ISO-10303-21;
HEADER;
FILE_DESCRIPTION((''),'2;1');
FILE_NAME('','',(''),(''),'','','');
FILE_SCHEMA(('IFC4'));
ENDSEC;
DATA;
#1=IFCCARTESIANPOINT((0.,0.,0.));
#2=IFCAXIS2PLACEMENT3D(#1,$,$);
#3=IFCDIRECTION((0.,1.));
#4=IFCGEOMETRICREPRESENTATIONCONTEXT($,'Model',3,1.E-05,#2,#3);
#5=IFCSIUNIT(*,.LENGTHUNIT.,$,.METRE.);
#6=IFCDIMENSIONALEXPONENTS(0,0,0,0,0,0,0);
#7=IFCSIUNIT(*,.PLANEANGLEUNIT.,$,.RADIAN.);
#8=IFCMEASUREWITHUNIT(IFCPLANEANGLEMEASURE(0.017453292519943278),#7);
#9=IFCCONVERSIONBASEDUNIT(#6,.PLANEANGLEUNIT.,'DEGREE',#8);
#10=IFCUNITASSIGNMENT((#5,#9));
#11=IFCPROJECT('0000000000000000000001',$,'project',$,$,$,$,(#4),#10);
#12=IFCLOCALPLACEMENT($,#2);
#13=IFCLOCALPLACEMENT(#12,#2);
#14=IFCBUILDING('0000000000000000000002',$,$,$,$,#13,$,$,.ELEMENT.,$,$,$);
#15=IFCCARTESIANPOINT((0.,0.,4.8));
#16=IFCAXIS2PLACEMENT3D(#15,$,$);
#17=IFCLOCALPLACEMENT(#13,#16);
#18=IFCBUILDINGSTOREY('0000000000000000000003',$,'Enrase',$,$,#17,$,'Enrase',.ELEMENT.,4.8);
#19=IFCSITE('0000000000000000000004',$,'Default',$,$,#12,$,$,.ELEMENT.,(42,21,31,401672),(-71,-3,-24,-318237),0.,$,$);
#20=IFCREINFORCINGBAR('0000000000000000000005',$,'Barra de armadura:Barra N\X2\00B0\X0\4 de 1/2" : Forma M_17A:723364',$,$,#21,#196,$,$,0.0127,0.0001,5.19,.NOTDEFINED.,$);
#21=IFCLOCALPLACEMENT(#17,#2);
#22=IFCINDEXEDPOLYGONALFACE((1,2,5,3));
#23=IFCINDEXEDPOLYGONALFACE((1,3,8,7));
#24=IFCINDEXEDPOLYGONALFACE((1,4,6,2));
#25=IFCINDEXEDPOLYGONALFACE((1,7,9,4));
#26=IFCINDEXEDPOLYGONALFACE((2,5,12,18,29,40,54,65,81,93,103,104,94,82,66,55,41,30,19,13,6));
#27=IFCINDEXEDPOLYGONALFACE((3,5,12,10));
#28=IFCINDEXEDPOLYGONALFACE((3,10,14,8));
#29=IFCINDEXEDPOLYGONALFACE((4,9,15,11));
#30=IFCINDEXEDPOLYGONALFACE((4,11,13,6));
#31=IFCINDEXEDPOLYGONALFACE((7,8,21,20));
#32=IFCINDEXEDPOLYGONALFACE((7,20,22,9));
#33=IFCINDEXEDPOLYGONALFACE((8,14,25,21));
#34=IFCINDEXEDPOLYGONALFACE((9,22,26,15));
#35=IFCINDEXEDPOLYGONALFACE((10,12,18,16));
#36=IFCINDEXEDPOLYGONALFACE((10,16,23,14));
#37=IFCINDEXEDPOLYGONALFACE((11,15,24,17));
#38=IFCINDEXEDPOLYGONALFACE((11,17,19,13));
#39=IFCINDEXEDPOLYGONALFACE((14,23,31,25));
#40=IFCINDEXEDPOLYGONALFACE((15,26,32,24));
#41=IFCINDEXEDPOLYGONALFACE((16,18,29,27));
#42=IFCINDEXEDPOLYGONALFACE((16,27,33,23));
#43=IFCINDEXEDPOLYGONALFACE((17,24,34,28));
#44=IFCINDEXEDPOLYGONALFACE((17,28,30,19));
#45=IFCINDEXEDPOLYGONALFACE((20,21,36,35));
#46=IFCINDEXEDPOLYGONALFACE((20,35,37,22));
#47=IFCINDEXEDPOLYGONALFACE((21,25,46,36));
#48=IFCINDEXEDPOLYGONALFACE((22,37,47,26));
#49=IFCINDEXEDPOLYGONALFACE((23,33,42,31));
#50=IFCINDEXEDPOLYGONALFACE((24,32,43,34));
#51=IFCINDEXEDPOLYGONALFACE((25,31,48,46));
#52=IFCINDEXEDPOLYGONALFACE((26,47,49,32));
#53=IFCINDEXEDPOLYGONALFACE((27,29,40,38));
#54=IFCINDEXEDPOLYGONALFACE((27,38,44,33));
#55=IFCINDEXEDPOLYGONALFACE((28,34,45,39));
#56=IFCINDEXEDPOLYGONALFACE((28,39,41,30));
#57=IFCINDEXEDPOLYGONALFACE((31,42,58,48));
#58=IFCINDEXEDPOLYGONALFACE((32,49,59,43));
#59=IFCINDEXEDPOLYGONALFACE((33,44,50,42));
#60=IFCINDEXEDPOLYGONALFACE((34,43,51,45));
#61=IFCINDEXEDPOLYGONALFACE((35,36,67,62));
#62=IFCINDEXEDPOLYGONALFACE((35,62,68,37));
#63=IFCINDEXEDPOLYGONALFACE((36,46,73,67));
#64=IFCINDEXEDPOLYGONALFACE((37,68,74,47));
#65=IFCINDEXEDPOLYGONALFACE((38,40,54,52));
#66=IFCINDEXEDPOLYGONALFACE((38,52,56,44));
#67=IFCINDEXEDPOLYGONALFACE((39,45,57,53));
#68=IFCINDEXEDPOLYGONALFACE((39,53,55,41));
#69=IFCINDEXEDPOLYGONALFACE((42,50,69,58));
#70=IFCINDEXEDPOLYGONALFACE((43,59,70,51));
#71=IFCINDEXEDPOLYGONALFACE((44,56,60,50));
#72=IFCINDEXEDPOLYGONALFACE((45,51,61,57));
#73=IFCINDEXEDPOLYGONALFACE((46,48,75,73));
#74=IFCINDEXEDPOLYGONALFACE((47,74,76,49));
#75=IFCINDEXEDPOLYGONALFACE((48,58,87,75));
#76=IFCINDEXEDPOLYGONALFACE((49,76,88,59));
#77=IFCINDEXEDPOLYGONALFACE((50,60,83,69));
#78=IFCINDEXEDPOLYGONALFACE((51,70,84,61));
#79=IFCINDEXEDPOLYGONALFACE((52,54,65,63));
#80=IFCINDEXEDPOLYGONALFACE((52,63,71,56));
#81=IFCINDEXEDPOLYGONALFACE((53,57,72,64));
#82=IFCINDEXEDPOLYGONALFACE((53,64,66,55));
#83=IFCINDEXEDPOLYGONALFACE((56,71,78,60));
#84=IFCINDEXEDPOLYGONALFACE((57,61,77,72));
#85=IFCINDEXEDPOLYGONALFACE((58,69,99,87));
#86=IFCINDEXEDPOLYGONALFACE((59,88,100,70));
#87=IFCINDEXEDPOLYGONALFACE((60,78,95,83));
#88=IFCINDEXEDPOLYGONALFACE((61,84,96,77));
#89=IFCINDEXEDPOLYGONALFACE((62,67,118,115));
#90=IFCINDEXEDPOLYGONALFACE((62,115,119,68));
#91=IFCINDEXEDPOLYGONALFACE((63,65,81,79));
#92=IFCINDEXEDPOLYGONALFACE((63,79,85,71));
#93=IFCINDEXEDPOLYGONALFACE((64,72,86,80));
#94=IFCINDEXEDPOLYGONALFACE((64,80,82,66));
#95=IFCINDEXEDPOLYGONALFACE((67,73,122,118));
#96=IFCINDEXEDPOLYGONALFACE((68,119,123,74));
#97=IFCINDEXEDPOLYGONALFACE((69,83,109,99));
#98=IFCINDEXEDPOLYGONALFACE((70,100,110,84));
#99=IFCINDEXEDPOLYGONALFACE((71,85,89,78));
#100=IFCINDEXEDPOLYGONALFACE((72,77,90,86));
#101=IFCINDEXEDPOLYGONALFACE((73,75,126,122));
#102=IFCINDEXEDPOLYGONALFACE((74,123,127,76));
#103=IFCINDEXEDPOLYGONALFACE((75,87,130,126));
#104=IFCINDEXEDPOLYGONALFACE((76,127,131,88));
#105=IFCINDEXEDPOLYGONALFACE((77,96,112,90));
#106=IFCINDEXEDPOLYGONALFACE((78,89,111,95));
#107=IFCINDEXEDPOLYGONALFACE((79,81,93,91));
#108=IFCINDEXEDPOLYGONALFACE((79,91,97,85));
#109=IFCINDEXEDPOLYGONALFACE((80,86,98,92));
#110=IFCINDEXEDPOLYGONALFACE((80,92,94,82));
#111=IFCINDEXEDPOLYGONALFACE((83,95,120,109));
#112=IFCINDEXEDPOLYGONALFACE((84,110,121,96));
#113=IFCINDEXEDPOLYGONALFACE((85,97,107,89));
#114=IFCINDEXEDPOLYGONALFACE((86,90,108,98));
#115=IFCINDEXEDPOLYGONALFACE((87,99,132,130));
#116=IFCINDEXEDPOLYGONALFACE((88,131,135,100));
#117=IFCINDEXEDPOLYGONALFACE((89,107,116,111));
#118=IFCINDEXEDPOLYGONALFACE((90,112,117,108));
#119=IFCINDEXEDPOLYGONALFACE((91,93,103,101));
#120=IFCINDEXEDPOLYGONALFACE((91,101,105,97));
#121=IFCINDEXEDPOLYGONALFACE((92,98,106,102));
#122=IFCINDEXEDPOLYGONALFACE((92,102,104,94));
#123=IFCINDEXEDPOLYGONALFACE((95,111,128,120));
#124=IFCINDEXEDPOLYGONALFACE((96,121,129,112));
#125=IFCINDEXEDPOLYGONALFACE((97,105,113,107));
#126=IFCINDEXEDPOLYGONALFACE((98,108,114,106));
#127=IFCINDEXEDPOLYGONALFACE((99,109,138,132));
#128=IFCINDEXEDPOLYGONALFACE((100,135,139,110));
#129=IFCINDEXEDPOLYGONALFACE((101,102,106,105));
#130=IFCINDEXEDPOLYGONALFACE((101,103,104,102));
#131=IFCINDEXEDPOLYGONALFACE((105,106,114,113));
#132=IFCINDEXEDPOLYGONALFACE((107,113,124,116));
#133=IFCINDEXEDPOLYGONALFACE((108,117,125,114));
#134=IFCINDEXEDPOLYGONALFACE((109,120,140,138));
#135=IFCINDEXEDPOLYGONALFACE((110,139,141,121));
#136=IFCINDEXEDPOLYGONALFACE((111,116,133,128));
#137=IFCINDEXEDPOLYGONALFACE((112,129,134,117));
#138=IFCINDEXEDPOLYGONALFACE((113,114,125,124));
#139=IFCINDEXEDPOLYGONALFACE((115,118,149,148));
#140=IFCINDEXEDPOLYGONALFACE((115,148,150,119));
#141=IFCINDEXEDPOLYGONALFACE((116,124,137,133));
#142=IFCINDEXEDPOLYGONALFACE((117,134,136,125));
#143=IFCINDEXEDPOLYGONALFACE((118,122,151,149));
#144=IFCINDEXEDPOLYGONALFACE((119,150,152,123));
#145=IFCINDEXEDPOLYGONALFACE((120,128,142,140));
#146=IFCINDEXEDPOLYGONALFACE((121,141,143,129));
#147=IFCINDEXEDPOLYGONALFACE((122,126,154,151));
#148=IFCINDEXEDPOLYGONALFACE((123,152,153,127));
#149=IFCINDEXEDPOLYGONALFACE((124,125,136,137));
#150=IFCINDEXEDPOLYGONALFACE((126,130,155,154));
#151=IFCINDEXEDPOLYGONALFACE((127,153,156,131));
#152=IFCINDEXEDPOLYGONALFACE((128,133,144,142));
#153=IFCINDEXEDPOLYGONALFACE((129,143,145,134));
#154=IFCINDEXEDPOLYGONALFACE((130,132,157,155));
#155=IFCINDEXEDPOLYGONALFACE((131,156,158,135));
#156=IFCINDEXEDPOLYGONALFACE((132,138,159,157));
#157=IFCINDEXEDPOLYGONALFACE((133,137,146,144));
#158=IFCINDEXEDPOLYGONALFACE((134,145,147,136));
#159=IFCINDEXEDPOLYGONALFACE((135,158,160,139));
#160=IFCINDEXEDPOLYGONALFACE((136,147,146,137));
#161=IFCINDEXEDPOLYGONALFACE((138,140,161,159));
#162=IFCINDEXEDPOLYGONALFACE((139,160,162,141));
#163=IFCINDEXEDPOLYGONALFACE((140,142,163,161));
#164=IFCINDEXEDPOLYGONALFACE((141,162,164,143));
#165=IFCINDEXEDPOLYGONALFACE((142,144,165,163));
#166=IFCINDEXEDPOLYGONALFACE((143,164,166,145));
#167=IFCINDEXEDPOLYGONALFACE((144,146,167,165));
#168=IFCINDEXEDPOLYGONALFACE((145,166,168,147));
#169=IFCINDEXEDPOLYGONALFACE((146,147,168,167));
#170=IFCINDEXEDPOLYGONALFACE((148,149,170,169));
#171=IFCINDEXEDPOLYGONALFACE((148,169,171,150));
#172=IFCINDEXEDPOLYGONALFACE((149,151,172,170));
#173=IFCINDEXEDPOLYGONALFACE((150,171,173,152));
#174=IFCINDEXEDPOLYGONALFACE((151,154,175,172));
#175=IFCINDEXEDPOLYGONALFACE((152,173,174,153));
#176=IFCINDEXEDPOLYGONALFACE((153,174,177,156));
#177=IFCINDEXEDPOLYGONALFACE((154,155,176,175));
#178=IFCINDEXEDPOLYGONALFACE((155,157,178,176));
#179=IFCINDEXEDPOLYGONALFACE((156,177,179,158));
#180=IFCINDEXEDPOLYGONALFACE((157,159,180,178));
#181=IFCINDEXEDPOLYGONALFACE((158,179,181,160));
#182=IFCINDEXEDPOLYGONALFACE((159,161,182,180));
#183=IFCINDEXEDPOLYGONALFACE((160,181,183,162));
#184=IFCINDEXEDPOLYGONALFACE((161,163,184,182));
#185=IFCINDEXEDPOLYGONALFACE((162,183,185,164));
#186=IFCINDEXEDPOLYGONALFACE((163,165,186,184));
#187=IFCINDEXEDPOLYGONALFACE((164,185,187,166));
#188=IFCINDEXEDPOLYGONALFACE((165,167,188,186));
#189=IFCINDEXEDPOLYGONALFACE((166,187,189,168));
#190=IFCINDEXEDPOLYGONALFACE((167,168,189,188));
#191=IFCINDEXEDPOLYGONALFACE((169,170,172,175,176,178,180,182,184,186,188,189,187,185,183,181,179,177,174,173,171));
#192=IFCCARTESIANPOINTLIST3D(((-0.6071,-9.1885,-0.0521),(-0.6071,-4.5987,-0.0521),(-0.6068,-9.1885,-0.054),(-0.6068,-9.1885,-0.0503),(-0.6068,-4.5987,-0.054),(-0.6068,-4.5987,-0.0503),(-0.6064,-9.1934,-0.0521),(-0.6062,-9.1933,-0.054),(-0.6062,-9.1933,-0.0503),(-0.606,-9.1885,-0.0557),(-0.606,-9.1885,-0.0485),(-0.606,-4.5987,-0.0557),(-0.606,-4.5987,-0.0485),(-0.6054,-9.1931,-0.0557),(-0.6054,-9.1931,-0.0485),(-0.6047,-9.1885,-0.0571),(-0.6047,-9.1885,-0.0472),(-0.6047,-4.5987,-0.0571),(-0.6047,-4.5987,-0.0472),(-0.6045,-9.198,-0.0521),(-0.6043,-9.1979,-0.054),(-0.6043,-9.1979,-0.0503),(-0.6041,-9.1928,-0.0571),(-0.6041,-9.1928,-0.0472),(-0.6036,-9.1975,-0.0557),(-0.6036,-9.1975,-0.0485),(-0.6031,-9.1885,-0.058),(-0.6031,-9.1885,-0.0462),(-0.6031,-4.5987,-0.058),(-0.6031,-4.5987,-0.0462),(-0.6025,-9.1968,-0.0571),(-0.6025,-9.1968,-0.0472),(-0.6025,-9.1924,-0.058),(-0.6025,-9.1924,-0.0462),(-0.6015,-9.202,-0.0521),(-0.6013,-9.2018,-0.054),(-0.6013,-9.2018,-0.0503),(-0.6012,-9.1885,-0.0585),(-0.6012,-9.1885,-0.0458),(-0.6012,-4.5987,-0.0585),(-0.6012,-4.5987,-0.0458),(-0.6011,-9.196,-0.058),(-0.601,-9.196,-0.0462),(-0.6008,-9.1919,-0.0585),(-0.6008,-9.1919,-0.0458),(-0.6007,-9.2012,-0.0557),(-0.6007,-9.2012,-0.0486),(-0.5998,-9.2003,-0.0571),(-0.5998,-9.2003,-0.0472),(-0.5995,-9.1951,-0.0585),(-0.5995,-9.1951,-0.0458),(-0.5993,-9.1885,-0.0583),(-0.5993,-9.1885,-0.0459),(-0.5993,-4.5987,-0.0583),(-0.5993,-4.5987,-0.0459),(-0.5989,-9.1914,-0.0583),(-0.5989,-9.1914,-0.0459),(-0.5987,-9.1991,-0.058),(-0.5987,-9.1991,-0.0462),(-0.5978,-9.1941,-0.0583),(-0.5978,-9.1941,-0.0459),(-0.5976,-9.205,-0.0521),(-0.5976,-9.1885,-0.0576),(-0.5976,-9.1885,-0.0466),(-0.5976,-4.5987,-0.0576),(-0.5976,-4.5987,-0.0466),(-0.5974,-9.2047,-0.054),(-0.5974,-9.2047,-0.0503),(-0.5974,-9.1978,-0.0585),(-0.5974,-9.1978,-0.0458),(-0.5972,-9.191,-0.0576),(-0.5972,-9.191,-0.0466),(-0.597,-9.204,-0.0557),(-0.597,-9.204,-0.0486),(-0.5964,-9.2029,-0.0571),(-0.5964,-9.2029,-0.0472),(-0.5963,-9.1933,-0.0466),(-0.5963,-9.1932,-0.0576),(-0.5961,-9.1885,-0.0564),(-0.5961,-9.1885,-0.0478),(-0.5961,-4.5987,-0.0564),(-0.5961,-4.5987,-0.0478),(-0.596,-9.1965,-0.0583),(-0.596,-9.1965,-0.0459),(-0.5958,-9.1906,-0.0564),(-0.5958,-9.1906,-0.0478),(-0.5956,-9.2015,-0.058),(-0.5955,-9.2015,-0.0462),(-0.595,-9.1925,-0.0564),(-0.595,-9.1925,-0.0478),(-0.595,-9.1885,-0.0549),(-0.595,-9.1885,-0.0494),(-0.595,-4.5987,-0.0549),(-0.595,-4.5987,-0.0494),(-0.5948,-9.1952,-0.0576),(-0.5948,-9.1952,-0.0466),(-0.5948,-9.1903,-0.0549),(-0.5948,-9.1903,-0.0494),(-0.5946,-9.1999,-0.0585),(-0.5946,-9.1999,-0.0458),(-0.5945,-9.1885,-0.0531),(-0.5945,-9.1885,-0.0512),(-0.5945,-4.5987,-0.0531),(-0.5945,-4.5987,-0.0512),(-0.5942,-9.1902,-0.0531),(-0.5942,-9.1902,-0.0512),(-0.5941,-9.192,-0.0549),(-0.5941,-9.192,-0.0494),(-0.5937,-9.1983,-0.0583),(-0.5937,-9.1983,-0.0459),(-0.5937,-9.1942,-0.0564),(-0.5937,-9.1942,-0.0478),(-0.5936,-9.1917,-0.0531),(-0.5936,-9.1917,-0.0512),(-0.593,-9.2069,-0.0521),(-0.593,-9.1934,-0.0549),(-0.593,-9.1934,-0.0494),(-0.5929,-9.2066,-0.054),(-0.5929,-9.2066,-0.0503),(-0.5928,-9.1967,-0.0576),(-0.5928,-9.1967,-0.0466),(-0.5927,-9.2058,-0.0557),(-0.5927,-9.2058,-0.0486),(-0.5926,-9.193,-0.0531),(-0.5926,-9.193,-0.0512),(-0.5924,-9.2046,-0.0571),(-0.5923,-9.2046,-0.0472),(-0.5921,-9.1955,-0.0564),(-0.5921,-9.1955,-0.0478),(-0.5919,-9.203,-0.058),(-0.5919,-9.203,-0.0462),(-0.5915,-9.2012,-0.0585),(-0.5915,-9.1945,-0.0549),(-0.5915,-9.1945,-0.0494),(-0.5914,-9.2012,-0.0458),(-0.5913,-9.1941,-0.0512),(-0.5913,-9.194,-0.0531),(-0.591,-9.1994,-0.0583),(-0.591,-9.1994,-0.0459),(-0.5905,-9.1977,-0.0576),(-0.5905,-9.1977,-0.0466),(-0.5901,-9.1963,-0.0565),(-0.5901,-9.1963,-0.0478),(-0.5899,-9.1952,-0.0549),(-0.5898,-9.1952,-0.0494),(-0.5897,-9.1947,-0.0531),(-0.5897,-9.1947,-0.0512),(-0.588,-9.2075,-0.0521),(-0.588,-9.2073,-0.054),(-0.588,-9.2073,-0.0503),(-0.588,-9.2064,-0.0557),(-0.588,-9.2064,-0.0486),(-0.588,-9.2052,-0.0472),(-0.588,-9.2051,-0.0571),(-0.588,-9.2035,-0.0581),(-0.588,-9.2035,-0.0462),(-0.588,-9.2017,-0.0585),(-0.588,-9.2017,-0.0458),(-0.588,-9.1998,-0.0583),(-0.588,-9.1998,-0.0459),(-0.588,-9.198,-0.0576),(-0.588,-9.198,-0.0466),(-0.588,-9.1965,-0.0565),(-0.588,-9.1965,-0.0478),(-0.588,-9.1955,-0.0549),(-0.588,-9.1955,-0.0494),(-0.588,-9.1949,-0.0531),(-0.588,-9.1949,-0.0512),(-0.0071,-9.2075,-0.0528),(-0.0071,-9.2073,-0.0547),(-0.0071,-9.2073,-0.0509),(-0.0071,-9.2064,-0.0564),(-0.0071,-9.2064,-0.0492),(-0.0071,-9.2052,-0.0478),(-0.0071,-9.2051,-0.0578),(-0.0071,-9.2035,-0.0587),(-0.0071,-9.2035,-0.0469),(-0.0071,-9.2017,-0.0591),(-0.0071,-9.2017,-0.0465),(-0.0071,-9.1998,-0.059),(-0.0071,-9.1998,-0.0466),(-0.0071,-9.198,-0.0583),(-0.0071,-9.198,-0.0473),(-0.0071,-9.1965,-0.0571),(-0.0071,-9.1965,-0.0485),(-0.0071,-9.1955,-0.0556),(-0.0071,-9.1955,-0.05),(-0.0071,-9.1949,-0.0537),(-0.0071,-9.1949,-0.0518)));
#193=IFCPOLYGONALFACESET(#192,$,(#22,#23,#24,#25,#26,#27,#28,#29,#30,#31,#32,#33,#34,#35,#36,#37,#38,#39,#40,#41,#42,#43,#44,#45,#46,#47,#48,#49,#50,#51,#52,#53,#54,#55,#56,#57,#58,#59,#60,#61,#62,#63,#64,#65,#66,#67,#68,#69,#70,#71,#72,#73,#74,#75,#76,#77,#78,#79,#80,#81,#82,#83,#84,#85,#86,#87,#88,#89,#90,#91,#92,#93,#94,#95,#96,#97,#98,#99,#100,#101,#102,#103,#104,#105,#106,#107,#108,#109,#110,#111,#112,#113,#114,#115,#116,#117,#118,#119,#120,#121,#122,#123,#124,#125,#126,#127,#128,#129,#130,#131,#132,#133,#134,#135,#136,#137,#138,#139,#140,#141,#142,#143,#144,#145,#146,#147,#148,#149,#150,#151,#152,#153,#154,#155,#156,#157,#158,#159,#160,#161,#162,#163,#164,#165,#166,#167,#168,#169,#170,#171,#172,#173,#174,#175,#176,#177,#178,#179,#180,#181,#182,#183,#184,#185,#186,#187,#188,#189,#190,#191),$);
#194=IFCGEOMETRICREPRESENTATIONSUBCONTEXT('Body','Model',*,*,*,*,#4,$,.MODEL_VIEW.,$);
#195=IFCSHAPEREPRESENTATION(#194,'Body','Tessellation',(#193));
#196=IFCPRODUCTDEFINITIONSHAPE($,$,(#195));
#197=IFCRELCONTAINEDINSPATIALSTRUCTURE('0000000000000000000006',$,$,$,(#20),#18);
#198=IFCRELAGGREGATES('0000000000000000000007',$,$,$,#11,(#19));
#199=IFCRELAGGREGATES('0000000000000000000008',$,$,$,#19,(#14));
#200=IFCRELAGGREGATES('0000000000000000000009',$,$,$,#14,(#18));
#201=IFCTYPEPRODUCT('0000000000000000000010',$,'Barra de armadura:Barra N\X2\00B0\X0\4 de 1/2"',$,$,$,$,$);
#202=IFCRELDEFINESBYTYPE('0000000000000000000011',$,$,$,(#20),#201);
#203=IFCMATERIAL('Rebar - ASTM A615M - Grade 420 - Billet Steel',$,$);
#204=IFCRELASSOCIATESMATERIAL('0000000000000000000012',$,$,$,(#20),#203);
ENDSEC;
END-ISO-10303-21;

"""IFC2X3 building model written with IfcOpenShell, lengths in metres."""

from ifc_helpers import new_model, entity, si_unit, converted_unit, direction, frame, origin, place, context, subcontext, project, spatial, material, type_object, element, save


model = new_model("IFC2X3")

# Units and contexts
model_context = context("Model", 3, precision=1e-05, world=origin(), true_north=direction((0.0, 1.0)))
body_context = subcontext(model_context, "Body", "Model", "MODEL_VIEW")
ifc_project = project(units=[si_unit("LENGTHUNIT", "METRE"), converted_unit("PLANEANGLEUNIT", "DEGREE", entity("IfcPlaneAngleMeasure", 0.017453292519943278), si_unit("PLANEANGLEUNIT", "RADIAN"), dimensions=[0, 0, 0, 0, 0, 0, 0])], contexts=[model_context])

# Site, building, storey
site_placement = place(None, origin())
site = spatial("IfcSite", under=ifc_project, at=site_placement, Name="Default", CompositionType="ELEMENT", RefLatitude=(42, 21, 31, 401672), RefLongitude=(-71, -3, -24, -318237), RefElevation=0.0)
building_placement = place(site_placement, origin())
building = spatial("IfcBuilding", under=site, at=building_placement, CompositionType="ELEMENT")
storey_placement = place(building_placement, frame((0.0, 0.0, 4.8)))
storey = spatial("IfcBuildingStorey", under=building, at=storey_placement, Name="Enrase", LongName="Enrase", CompositionType="ELEMENT", Elevation=4.8)

# Reinforcing bar
ifc_material = material(Name="Rebar - ASTM A615M - Grade 420 - Billet Steel")
type_product_1 = type_object("IfcTypeProduct", Name="Barra de armadura:Barra N°4 de 1/2\"")
reinforcing_bar_1_placement = place(storey_placement, origin())
element("IfcReinforcingBar", 1, at=reinforcing_bar_1_placement, inside=storey, type_object=type_product_1, material=ifc_material, Name="Barra de armadura:Barra N°4 de 1/2\" : Forma M_17A:723364", BarLength=5.19, BarRole="NOTDEFINED", CrossSectionArea=0.0001, NominalDiameter=0.0127, context=body_context, shape_type="AdvancedSweptSolid", body=[
    entity("IfcSweptDiskSolid", entity("IfcCompositeCurve", [entity("IfcCompositeCurveSegment", "CONTINUOUS", True, entity("IfcPolyline", [entity("IfcCartesianPoint", [-0.6007, -4.5987, -0.0521]), entity("IfcCartesianPoint", [-0.6007, -9.1885, -0.0521])])), entity("IfcCompositeCurveSegment", "CONTINUOUS", True, entity("IfcTrimmedCurve", entity("IfcCircle", entity("IfcAxis2Placement3D", entity("IfcCartesianPoint", [-0.588, -9.1885, -0.0521]), entity("IfcDirection", [0.001144, 0.0, 0.999999]), entity("IfcDirection", [0.0, -1.0, 0.0])), 0.0127), [entity("IfcParameterValue", 270.0)], [entity("IfcParameterValue", 360.0)], True, "PARAMETER")), entity("IfcCompositeCurveSegment", "CONTINUOUS", True, entity("IfcPolyline", [entity("IfcCartesianPoint", [-0.588, -9.2012, -0.0521]), entity("IfcCartesianPoint", [-0.0071, -9.2012, -0.0528])]))], False), 0.0063, None, 0.0, 92.0),
])

save(model, "model.ifc")
